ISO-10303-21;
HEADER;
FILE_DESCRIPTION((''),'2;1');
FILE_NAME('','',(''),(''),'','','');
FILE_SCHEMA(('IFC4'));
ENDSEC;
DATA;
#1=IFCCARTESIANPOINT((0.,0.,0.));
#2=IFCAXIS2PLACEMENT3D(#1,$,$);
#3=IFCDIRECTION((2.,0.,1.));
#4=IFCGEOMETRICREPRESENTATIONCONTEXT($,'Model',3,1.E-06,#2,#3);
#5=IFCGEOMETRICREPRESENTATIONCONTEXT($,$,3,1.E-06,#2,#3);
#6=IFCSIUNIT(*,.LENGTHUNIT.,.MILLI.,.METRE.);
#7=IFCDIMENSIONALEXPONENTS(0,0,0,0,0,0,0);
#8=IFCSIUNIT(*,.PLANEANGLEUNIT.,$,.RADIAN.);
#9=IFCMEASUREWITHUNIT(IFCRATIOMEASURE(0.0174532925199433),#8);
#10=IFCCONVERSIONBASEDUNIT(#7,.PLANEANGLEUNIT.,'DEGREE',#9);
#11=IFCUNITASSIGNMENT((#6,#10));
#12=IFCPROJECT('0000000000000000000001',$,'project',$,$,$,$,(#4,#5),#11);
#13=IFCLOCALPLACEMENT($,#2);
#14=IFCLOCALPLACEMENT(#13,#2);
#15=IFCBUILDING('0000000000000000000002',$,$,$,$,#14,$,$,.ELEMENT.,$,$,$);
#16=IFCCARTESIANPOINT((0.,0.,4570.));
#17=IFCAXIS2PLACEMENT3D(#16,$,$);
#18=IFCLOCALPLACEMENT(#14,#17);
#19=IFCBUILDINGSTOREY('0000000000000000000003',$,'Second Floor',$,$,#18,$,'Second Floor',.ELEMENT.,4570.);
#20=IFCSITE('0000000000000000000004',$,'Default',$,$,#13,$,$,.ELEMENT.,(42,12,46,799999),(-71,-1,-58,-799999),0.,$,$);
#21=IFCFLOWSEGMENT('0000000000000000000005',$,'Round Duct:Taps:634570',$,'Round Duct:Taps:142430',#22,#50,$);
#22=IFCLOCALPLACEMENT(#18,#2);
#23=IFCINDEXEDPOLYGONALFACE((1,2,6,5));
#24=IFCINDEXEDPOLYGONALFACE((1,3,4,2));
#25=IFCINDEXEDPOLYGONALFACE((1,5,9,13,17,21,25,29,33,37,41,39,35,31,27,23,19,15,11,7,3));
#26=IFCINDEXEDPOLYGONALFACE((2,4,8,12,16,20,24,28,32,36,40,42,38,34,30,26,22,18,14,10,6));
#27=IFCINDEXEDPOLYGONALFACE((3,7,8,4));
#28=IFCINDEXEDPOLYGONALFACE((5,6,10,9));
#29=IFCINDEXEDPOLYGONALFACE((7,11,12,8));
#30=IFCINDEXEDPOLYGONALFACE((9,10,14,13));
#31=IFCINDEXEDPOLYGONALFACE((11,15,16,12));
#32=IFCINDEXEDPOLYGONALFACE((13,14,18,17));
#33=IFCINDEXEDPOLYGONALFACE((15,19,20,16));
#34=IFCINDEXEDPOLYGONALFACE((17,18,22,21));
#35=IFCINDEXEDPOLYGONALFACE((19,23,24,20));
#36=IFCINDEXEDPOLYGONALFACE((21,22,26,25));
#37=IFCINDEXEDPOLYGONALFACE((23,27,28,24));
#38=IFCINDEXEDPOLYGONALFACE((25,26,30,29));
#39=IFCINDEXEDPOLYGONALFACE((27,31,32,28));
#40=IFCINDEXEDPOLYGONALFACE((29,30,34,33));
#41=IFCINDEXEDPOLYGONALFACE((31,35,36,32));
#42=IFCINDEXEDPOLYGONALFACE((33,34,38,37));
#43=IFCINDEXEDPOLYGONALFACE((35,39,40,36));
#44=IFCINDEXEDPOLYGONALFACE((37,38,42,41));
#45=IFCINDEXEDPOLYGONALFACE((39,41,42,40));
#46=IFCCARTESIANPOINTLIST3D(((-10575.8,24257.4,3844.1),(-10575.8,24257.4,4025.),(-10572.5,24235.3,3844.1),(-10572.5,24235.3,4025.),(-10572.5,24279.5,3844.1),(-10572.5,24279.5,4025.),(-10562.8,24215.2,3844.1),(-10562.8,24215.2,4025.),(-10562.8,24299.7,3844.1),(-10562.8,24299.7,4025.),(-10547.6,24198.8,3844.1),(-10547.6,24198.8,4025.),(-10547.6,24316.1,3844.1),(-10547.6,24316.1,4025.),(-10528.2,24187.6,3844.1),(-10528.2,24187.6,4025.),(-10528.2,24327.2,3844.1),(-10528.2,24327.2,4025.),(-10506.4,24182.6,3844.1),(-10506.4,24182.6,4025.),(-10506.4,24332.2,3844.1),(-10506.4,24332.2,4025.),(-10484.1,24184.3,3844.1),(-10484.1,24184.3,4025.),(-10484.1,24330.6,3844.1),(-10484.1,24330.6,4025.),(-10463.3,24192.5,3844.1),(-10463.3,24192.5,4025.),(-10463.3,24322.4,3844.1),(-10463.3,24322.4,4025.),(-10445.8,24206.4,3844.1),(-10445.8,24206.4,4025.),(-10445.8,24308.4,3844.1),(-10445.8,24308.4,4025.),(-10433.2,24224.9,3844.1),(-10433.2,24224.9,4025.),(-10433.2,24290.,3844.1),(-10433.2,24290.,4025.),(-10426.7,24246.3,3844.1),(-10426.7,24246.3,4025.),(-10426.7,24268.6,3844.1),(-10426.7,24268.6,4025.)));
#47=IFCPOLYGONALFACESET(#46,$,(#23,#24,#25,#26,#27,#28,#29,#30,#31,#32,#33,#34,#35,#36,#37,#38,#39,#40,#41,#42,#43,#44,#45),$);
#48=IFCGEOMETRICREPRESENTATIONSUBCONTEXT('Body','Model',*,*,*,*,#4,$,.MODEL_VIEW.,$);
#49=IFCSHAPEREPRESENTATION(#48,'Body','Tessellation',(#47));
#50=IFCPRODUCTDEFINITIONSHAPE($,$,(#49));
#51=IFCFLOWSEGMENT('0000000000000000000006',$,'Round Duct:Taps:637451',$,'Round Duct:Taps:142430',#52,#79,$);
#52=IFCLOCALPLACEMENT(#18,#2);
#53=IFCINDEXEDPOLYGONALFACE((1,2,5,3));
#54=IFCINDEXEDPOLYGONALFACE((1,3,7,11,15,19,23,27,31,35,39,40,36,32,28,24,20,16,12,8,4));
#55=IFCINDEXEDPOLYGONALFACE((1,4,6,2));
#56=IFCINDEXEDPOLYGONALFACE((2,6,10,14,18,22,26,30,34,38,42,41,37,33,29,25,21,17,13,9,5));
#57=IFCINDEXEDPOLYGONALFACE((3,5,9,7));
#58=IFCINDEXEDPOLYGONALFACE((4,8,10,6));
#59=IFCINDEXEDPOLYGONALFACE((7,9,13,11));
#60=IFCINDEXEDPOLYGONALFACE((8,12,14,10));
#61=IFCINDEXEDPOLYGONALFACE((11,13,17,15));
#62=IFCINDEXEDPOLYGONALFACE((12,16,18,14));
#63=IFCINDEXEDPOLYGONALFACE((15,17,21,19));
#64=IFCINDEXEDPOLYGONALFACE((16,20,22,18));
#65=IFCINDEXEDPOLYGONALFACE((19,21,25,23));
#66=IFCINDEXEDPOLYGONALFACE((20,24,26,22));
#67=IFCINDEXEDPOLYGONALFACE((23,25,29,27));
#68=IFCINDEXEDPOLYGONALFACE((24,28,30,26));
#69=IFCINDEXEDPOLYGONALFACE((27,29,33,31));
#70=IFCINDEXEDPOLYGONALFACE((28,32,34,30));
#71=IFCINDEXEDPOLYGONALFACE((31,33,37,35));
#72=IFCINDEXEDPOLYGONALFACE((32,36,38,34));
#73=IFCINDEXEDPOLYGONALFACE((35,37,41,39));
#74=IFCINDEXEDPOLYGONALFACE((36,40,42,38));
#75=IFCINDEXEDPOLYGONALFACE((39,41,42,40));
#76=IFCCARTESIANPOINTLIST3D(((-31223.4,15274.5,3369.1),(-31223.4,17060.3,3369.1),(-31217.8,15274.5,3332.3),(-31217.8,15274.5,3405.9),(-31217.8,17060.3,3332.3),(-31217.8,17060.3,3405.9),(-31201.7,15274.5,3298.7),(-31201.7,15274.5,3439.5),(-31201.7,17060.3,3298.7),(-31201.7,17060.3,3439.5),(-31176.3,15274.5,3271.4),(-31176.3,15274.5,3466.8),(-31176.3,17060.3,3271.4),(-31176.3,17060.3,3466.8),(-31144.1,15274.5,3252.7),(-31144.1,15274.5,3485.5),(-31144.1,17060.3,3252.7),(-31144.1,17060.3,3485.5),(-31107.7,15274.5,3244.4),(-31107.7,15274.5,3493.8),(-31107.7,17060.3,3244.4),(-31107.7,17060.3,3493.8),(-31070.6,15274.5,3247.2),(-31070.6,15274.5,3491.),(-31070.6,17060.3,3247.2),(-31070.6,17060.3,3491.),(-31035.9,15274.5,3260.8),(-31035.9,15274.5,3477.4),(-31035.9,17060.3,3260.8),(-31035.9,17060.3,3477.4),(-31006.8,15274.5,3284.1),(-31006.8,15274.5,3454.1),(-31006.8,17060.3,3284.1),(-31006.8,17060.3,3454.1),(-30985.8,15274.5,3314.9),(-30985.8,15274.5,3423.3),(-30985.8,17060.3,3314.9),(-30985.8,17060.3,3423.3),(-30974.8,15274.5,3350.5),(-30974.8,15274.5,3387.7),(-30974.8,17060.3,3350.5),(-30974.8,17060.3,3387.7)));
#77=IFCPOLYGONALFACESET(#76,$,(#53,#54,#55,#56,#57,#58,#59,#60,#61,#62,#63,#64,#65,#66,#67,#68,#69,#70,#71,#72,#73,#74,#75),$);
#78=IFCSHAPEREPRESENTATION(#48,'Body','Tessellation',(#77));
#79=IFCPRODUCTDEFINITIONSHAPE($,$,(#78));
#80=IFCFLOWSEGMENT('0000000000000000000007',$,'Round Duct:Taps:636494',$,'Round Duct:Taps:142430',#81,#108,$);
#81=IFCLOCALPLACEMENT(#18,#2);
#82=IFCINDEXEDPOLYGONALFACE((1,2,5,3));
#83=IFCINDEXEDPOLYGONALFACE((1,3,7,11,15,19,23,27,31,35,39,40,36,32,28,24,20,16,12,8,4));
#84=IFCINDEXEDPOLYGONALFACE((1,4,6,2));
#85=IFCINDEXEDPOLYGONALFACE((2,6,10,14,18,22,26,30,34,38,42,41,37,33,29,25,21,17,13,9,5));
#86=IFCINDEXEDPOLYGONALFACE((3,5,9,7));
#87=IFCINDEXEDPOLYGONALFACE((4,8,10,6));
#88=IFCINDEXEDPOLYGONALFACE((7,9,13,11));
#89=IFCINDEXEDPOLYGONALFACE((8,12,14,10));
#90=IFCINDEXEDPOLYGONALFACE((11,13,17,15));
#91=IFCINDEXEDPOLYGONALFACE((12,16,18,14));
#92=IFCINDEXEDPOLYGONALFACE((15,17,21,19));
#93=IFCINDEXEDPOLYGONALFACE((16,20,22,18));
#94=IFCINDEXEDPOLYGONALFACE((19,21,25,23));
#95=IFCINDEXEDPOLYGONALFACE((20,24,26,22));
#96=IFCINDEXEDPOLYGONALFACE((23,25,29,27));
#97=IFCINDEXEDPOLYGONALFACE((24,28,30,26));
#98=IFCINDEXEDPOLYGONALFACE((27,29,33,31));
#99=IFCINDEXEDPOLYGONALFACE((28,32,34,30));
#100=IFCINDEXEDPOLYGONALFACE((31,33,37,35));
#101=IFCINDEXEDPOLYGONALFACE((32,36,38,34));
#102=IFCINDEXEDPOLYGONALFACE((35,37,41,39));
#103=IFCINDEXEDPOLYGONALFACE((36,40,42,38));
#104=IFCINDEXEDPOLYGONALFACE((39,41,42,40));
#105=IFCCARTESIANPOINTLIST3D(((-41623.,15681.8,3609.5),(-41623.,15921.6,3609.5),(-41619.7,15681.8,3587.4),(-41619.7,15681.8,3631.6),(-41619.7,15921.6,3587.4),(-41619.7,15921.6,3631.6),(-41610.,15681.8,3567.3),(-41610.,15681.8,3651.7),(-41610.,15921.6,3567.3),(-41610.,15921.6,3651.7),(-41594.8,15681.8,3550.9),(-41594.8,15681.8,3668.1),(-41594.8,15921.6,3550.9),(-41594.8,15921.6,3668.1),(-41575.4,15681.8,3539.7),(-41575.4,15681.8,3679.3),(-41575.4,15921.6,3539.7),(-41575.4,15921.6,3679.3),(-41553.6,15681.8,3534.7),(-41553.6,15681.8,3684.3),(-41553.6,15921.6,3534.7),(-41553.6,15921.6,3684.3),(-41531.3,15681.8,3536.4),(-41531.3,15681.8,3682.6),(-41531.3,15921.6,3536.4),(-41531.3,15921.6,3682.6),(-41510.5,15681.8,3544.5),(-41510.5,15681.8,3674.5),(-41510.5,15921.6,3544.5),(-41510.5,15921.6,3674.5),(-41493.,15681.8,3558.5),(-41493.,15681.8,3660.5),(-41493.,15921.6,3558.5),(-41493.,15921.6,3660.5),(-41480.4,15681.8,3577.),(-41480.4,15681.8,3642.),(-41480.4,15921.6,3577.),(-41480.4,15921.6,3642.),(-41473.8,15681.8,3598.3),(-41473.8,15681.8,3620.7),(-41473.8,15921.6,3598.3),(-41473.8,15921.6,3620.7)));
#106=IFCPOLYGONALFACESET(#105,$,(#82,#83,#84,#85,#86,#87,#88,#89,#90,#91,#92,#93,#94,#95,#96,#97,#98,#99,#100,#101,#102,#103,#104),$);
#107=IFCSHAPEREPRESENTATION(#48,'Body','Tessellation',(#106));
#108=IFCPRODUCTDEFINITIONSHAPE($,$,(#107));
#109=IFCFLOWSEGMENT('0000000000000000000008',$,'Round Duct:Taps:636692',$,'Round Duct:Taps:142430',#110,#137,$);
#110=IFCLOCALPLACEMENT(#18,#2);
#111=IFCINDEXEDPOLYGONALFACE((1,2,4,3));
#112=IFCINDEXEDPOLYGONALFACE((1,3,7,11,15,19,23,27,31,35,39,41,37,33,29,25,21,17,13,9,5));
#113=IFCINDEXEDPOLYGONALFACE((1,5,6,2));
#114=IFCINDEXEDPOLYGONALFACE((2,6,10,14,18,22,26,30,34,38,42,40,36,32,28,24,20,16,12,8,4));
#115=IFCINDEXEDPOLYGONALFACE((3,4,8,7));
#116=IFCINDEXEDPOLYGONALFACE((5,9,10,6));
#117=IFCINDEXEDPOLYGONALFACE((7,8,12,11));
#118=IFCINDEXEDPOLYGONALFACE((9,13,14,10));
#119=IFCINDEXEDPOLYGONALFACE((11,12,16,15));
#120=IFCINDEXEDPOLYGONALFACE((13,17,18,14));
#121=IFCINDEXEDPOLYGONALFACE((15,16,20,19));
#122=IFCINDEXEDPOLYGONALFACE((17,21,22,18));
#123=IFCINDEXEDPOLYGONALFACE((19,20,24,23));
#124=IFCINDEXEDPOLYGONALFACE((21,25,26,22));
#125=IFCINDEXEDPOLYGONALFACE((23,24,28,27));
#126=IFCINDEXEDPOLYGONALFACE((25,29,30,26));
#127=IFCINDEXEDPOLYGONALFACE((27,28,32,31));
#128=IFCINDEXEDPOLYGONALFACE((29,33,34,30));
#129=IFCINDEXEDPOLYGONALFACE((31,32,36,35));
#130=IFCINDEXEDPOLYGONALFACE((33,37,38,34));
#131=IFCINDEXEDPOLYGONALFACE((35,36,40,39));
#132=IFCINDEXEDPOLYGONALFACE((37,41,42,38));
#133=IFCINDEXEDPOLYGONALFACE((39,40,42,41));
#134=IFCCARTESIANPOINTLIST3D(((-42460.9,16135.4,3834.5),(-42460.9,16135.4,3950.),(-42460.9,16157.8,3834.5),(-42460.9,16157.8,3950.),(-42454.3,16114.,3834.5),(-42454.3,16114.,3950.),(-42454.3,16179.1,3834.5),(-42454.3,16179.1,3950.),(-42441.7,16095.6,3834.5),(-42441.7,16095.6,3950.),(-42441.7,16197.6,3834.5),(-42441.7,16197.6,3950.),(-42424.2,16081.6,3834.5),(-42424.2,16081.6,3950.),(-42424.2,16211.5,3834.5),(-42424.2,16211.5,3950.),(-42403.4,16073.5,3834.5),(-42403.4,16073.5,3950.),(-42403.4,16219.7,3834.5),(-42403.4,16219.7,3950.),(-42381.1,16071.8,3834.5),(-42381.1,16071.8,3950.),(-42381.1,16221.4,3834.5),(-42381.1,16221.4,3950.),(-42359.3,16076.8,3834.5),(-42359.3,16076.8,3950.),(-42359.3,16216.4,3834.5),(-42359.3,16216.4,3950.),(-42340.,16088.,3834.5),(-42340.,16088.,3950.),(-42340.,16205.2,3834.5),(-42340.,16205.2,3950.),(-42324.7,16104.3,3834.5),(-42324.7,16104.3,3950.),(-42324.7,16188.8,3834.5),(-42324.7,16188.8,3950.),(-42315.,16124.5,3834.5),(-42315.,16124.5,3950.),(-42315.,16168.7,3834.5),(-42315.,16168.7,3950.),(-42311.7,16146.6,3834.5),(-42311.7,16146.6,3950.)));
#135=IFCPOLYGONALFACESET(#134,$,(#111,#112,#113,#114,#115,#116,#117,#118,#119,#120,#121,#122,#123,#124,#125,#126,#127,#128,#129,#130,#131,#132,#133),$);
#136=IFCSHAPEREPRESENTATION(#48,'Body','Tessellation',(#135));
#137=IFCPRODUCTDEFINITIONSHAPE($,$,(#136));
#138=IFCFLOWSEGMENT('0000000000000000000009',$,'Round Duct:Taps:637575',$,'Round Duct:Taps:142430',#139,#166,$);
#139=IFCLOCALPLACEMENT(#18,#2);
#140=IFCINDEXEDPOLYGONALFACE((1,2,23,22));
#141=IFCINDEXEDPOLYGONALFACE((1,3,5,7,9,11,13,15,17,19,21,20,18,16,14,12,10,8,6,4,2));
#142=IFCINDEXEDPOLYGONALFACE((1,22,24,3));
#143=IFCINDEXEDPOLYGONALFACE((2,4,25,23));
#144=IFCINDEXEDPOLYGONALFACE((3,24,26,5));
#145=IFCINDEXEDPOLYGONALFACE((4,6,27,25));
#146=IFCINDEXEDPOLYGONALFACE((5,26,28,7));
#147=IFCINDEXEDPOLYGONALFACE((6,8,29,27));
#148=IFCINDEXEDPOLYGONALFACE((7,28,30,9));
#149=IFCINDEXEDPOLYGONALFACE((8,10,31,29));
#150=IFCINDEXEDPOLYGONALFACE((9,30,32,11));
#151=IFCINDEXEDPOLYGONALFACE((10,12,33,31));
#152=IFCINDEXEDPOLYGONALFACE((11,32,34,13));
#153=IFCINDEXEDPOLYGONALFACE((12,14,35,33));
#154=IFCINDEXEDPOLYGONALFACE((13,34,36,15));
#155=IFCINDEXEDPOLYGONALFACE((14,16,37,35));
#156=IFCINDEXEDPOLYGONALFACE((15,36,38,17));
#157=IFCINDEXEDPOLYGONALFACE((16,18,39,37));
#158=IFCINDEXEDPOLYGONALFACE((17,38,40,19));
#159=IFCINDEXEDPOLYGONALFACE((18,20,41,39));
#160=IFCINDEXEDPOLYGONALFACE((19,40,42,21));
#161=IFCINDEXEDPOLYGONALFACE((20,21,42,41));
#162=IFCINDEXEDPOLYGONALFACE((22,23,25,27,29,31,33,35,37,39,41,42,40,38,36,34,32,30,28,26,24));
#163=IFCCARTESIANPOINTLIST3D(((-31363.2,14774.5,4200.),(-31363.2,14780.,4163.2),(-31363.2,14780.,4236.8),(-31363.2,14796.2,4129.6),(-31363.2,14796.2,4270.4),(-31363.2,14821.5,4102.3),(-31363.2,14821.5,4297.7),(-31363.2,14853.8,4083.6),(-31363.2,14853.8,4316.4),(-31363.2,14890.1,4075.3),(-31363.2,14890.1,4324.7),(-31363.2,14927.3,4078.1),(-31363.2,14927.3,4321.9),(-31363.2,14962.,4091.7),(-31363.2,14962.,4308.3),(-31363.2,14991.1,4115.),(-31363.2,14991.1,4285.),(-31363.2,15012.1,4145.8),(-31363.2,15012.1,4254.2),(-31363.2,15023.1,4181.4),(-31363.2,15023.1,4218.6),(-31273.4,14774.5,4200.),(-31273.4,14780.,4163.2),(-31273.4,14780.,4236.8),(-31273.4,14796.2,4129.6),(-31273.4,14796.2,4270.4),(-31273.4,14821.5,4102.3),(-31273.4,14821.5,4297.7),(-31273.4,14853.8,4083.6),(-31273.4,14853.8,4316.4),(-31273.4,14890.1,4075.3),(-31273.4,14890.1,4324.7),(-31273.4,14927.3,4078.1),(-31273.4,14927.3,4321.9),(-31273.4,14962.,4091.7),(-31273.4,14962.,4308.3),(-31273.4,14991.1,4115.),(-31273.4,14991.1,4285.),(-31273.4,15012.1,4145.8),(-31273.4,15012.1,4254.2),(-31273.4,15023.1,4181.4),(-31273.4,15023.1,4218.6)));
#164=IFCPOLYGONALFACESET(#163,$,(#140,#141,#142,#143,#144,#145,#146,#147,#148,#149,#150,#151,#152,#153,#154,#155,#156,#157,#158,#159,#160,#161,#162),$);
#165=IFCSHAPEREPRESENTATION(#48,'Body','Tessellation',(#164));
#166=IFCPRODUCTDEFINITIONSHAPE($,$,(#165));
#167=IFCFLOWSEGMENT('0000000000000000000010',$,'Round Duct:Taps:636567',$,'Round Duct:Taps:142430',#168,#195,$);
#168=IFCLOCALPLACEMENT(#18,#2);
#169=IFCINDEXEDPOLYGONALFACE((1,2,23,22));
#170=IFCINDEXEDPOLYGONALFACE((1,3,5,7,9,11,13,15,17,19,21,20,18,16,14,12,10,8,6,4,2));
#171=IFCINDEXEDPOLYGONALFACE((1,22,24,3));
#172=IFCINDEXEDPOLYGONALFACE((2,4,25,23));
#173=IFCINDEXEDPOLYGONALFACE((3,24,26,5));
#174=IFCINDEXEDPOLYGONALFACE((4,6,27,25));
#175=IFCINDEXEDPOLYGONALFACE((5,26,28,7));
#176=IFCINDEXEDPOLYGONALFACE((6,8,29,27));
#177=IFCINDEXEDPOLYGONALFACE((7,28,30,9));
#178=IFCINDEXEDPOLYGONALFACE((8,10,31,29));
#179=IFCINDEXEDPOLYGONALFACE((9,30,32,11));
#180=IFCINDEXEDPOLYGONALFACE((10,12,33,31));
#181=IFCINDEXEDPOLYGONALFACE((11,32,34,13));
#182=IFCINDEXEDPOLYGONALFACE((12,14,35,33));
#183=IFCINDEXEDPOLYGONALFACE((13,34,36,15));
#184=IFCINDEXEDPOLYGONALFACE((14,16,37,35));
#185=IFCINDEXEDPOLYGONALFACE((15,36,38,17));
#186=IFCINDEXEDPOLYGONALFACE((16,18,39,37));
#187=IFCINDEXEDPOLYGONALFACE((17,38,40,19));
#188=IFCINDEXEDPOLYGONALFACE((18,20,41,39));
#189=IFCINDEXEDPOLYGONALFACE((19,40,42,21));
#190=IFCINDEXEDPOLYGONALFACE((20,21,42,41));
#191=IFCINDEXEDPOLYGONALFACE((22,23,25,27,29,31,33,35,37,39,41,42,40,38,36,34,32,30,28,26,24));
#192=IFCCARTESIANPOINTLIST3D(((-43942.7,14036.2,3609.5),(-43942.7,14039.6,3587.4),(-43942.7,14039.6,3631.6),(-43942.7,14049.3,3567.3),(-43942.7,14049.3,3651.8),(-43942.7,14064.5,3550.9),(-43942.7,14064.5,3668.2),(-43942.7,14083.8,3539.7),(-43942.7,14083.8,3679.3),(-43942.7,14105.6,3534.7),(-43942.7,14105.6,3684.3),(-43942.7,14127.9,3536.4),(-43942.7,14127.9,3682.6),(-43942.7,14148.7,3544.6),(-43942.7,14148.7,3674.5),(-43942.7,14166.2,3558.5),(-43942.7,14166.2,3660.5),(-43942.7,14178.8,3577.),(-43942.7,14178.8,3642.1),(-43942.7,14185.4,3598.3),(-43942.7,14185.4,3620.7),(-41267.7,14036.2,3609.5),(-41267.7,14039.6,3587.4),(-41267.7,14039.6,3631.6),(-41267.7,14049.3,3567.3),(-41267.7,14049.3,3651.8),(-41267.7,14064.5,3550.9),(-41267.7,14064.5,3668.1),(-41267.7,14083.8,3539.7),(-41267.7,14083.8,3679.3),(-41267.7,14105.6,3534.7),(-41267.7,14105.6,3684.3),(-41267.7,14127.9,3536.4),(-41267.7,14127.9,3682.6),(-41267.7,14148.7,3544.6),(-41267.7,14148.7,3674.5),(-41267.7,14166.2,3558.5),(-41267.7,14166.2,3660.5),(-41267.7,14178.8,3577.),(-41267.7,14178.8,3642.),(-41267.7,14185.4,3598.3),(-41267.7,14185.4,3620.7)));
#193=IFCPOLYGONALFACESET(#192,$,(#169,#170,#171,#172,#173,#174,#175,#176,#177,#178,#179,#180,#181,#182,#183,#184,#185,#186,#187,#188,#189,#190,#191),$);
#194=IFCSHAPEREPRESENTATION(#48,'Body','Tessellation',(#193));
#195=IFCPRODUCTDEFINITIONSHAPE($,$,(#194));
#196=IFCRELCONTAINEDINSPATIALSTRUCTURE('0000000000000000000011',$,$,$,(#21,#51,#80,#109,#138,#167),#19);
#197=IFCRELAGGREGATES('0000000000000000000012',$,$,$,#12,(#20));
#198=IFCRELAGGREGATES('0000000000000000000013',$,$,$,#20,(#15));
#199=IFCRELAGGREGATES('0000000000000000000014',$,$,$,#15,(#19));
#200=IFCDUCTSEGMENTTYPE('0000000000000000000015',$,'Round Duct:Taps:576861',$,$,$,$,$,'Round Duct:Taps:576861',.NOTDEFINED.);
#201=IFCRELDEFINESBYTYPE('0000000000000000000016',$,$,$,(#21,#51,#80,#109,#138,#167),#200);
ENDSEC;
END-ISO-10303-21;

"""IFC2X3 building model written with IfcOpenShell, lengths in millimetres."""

from ifc_helpers import new_model, entity, si_unit, converted_unit, direction, frame, frame_2d, origin, origin_2d_with_axis, place, context, subcontext, project, spatial, circle, extrude, type_object, element, save


model = new_model("IFC2X3")

# Units and contexts
model_context = context("Model", 3, precision=1e-06, world=origin(), true_north=direction((2.0, 0.0, 1.0)))
context_of_model = context(None, 3, precision=1e-06, world=origin(), true_north=direction((2.0, 0.0, 1.0)))
body_context = subcontext(model_context, "Body", "Model", "MODEL_VIEW")
ifc_project = project(units=[si_unit("LENGTHUNIT", "METRE", prefix="MILLI"), converted_unit("PLANEANGLEUNIT", "DEGREE", entity("IfcRatioMeasure", 0.0174532925199433), si_unit("PLANEANGLEUNIT", "RADIAN"), dimensions=[0, 0, 0, 0, 0, 0, 0])], contexts=[model_context, context_of_model])

# Site, building, storey
site_placement = place(None, origin())
site = spatial("IfcSite", under=ifc_project, at=site_placement, Name="Default", CompositionType="ELEMENT", RefLatitude=(42, 12, 46, 799999), RefLongitude=(-71, -1, -58, -799999), RefElevation=0.0)
building_placement = place(site_placement, origin())
building = spatial("IfcBuilding", under=site, at=building_placement, CompositionType="ELEMENT")
storey_placement = place(building_placement, frame((0.0, 0.0, 4570.0)))
storey = spatial("IfcBuildingStorey", under=building, at=storey_placement, Name="Second Floor", LongName="Second Floor", CompositionType="ELEMENT", Elevation=4570.0)

# Flow segments
duct_segment_type_1 = type_object("IfcDuctSegmentType", Name="Round Duct:Taps:576861", ElementType="Round Duct:Taps:576861", PredefinedType="NOTDEFINED")
flow_segment_1_placement = place(storey_placement, origin())
element("IfcFlowSegment", 1, at=flow_segment_1_placement, inside=storey, type_object=duct_segment_type_1, Name="Round Duct:Taps:634570", ObjectType="Round Duct:Taps:142430", context=body_context, shape_type="SweptSolid", body=[
    extrude(circle(Radius=75.0, at=frame_2d((0.0, 0.0), x_axis=(1.0, 0.0))), frame((-10500.8, 24257.4, 3844.1), z_axis=(0.0, 0.0, 1.0), x_axis=(-1.0, 0.0, 0.0)), (0.0, 0.0, 1.0), 180.9),
])
flow_segment_2_placement = place(storey_placement, origin())
element("IfcFlowSegment", 2, at=flow_segment_2_placement, inside=storey, type_object=duct_segment_type_1, Name="Round Duct:Taps:637451", ObjectType="Round Duct:Taps:142430", context=body_context, shape_type="SweptSolid", body=[
    extrude(circle(Radius=125.0, at=origin_2d_with_axis()), frame((-31098.4, 15274.5, 3369.1), z_axis=(0.0, 1.0, 0.0), x_axis=(-1.0, 0.0, 0.0)), (0.0, 0.0, 1.0), 1785.8),
])
flow_segment_3_placement = place(storey_placement, origin())
element("IfcFlowSegment", 3, at=flow_segment_3_placement, inside=storey, type_object=duct_segment_type_1, Name="Round Duct:Taps:636494", ObjectType="Round Duct:Taps:142430", context=body_context, shape_type="SweptSolid", body=[
    extrude(circle(Radius=75.0, at=frame_2d((0.0, 0.0), x_axis=(1.0, 0.0))), frame((-41548.0, 15681.8, 3609.5), z_axis=(0.0, 1.0, 0.0), x_axis=(-1.0, 0.0, 0.0)), (0.0, 0.0, 1.0), 239.8),
])
flow_segment_4_placement = place(storey_placement, origin())
element("IfcFlowSegment", 4, at=flow_segment_4_placement, inside=storey, type_object=duct_segment_type_1, Name="Round Duct:Taps:636692", ObjectType="Round Duct:Taps:142430", context=body_context, shape_type="SweptSolid", body=[
    extrude(circle(Radius=75.0, at=frame_2d((0.0, 0.0), x_axis=(1.0, 0.0))), frame((-42386.7, 16146.6, 3834.5)), (0.0, 0.0, 1.0), 115.5),
])
flow_segment_5_placement = place(storey_placement, origin())
element("IfcFlowSegment", 5, at=flow_segment_5_placement, inside=storey, type_object=duct_segment_type_1, Name="Round Duct:Taps:637575", ObjectType="Round Duct:Taps:142430", context=body_context, shape_type="SweptSolid", body=[
    extrude(circle(Radius=125.0, at=origin_2d_with_axis()), frame((-31363.2, 14899.5, 4200.0), z_axis=(1.0, 0.0, 0.0), x_axis=(0.0, -1.0, 0.0)), (0.0, 0.0, 1.0), 89.8),
])
flow_segment_6_placement = place(storey_placement, origin())
element("IfcFlowSegment", 6, at=flow_segment_6_placement, inside=storey, type_object=duct_segment_type_1, Name="Round Duct:Taps:636567", ObjectType="Round Duct:Taps:142430", context=body_context, shape_type="SweptSolid", body=[
    extrude(circle(Radius=75.0, at=origin_2d_with_axis()), frame((-43942.7, 14111.2, 3609.5), z_axis=(1.0, 0.0, -0.000009), x_axis=(0.0, -1.0, 0.0)), (0.0, 0.0, 1.0), 2675.0),
])

save(model, "model.ifc")
